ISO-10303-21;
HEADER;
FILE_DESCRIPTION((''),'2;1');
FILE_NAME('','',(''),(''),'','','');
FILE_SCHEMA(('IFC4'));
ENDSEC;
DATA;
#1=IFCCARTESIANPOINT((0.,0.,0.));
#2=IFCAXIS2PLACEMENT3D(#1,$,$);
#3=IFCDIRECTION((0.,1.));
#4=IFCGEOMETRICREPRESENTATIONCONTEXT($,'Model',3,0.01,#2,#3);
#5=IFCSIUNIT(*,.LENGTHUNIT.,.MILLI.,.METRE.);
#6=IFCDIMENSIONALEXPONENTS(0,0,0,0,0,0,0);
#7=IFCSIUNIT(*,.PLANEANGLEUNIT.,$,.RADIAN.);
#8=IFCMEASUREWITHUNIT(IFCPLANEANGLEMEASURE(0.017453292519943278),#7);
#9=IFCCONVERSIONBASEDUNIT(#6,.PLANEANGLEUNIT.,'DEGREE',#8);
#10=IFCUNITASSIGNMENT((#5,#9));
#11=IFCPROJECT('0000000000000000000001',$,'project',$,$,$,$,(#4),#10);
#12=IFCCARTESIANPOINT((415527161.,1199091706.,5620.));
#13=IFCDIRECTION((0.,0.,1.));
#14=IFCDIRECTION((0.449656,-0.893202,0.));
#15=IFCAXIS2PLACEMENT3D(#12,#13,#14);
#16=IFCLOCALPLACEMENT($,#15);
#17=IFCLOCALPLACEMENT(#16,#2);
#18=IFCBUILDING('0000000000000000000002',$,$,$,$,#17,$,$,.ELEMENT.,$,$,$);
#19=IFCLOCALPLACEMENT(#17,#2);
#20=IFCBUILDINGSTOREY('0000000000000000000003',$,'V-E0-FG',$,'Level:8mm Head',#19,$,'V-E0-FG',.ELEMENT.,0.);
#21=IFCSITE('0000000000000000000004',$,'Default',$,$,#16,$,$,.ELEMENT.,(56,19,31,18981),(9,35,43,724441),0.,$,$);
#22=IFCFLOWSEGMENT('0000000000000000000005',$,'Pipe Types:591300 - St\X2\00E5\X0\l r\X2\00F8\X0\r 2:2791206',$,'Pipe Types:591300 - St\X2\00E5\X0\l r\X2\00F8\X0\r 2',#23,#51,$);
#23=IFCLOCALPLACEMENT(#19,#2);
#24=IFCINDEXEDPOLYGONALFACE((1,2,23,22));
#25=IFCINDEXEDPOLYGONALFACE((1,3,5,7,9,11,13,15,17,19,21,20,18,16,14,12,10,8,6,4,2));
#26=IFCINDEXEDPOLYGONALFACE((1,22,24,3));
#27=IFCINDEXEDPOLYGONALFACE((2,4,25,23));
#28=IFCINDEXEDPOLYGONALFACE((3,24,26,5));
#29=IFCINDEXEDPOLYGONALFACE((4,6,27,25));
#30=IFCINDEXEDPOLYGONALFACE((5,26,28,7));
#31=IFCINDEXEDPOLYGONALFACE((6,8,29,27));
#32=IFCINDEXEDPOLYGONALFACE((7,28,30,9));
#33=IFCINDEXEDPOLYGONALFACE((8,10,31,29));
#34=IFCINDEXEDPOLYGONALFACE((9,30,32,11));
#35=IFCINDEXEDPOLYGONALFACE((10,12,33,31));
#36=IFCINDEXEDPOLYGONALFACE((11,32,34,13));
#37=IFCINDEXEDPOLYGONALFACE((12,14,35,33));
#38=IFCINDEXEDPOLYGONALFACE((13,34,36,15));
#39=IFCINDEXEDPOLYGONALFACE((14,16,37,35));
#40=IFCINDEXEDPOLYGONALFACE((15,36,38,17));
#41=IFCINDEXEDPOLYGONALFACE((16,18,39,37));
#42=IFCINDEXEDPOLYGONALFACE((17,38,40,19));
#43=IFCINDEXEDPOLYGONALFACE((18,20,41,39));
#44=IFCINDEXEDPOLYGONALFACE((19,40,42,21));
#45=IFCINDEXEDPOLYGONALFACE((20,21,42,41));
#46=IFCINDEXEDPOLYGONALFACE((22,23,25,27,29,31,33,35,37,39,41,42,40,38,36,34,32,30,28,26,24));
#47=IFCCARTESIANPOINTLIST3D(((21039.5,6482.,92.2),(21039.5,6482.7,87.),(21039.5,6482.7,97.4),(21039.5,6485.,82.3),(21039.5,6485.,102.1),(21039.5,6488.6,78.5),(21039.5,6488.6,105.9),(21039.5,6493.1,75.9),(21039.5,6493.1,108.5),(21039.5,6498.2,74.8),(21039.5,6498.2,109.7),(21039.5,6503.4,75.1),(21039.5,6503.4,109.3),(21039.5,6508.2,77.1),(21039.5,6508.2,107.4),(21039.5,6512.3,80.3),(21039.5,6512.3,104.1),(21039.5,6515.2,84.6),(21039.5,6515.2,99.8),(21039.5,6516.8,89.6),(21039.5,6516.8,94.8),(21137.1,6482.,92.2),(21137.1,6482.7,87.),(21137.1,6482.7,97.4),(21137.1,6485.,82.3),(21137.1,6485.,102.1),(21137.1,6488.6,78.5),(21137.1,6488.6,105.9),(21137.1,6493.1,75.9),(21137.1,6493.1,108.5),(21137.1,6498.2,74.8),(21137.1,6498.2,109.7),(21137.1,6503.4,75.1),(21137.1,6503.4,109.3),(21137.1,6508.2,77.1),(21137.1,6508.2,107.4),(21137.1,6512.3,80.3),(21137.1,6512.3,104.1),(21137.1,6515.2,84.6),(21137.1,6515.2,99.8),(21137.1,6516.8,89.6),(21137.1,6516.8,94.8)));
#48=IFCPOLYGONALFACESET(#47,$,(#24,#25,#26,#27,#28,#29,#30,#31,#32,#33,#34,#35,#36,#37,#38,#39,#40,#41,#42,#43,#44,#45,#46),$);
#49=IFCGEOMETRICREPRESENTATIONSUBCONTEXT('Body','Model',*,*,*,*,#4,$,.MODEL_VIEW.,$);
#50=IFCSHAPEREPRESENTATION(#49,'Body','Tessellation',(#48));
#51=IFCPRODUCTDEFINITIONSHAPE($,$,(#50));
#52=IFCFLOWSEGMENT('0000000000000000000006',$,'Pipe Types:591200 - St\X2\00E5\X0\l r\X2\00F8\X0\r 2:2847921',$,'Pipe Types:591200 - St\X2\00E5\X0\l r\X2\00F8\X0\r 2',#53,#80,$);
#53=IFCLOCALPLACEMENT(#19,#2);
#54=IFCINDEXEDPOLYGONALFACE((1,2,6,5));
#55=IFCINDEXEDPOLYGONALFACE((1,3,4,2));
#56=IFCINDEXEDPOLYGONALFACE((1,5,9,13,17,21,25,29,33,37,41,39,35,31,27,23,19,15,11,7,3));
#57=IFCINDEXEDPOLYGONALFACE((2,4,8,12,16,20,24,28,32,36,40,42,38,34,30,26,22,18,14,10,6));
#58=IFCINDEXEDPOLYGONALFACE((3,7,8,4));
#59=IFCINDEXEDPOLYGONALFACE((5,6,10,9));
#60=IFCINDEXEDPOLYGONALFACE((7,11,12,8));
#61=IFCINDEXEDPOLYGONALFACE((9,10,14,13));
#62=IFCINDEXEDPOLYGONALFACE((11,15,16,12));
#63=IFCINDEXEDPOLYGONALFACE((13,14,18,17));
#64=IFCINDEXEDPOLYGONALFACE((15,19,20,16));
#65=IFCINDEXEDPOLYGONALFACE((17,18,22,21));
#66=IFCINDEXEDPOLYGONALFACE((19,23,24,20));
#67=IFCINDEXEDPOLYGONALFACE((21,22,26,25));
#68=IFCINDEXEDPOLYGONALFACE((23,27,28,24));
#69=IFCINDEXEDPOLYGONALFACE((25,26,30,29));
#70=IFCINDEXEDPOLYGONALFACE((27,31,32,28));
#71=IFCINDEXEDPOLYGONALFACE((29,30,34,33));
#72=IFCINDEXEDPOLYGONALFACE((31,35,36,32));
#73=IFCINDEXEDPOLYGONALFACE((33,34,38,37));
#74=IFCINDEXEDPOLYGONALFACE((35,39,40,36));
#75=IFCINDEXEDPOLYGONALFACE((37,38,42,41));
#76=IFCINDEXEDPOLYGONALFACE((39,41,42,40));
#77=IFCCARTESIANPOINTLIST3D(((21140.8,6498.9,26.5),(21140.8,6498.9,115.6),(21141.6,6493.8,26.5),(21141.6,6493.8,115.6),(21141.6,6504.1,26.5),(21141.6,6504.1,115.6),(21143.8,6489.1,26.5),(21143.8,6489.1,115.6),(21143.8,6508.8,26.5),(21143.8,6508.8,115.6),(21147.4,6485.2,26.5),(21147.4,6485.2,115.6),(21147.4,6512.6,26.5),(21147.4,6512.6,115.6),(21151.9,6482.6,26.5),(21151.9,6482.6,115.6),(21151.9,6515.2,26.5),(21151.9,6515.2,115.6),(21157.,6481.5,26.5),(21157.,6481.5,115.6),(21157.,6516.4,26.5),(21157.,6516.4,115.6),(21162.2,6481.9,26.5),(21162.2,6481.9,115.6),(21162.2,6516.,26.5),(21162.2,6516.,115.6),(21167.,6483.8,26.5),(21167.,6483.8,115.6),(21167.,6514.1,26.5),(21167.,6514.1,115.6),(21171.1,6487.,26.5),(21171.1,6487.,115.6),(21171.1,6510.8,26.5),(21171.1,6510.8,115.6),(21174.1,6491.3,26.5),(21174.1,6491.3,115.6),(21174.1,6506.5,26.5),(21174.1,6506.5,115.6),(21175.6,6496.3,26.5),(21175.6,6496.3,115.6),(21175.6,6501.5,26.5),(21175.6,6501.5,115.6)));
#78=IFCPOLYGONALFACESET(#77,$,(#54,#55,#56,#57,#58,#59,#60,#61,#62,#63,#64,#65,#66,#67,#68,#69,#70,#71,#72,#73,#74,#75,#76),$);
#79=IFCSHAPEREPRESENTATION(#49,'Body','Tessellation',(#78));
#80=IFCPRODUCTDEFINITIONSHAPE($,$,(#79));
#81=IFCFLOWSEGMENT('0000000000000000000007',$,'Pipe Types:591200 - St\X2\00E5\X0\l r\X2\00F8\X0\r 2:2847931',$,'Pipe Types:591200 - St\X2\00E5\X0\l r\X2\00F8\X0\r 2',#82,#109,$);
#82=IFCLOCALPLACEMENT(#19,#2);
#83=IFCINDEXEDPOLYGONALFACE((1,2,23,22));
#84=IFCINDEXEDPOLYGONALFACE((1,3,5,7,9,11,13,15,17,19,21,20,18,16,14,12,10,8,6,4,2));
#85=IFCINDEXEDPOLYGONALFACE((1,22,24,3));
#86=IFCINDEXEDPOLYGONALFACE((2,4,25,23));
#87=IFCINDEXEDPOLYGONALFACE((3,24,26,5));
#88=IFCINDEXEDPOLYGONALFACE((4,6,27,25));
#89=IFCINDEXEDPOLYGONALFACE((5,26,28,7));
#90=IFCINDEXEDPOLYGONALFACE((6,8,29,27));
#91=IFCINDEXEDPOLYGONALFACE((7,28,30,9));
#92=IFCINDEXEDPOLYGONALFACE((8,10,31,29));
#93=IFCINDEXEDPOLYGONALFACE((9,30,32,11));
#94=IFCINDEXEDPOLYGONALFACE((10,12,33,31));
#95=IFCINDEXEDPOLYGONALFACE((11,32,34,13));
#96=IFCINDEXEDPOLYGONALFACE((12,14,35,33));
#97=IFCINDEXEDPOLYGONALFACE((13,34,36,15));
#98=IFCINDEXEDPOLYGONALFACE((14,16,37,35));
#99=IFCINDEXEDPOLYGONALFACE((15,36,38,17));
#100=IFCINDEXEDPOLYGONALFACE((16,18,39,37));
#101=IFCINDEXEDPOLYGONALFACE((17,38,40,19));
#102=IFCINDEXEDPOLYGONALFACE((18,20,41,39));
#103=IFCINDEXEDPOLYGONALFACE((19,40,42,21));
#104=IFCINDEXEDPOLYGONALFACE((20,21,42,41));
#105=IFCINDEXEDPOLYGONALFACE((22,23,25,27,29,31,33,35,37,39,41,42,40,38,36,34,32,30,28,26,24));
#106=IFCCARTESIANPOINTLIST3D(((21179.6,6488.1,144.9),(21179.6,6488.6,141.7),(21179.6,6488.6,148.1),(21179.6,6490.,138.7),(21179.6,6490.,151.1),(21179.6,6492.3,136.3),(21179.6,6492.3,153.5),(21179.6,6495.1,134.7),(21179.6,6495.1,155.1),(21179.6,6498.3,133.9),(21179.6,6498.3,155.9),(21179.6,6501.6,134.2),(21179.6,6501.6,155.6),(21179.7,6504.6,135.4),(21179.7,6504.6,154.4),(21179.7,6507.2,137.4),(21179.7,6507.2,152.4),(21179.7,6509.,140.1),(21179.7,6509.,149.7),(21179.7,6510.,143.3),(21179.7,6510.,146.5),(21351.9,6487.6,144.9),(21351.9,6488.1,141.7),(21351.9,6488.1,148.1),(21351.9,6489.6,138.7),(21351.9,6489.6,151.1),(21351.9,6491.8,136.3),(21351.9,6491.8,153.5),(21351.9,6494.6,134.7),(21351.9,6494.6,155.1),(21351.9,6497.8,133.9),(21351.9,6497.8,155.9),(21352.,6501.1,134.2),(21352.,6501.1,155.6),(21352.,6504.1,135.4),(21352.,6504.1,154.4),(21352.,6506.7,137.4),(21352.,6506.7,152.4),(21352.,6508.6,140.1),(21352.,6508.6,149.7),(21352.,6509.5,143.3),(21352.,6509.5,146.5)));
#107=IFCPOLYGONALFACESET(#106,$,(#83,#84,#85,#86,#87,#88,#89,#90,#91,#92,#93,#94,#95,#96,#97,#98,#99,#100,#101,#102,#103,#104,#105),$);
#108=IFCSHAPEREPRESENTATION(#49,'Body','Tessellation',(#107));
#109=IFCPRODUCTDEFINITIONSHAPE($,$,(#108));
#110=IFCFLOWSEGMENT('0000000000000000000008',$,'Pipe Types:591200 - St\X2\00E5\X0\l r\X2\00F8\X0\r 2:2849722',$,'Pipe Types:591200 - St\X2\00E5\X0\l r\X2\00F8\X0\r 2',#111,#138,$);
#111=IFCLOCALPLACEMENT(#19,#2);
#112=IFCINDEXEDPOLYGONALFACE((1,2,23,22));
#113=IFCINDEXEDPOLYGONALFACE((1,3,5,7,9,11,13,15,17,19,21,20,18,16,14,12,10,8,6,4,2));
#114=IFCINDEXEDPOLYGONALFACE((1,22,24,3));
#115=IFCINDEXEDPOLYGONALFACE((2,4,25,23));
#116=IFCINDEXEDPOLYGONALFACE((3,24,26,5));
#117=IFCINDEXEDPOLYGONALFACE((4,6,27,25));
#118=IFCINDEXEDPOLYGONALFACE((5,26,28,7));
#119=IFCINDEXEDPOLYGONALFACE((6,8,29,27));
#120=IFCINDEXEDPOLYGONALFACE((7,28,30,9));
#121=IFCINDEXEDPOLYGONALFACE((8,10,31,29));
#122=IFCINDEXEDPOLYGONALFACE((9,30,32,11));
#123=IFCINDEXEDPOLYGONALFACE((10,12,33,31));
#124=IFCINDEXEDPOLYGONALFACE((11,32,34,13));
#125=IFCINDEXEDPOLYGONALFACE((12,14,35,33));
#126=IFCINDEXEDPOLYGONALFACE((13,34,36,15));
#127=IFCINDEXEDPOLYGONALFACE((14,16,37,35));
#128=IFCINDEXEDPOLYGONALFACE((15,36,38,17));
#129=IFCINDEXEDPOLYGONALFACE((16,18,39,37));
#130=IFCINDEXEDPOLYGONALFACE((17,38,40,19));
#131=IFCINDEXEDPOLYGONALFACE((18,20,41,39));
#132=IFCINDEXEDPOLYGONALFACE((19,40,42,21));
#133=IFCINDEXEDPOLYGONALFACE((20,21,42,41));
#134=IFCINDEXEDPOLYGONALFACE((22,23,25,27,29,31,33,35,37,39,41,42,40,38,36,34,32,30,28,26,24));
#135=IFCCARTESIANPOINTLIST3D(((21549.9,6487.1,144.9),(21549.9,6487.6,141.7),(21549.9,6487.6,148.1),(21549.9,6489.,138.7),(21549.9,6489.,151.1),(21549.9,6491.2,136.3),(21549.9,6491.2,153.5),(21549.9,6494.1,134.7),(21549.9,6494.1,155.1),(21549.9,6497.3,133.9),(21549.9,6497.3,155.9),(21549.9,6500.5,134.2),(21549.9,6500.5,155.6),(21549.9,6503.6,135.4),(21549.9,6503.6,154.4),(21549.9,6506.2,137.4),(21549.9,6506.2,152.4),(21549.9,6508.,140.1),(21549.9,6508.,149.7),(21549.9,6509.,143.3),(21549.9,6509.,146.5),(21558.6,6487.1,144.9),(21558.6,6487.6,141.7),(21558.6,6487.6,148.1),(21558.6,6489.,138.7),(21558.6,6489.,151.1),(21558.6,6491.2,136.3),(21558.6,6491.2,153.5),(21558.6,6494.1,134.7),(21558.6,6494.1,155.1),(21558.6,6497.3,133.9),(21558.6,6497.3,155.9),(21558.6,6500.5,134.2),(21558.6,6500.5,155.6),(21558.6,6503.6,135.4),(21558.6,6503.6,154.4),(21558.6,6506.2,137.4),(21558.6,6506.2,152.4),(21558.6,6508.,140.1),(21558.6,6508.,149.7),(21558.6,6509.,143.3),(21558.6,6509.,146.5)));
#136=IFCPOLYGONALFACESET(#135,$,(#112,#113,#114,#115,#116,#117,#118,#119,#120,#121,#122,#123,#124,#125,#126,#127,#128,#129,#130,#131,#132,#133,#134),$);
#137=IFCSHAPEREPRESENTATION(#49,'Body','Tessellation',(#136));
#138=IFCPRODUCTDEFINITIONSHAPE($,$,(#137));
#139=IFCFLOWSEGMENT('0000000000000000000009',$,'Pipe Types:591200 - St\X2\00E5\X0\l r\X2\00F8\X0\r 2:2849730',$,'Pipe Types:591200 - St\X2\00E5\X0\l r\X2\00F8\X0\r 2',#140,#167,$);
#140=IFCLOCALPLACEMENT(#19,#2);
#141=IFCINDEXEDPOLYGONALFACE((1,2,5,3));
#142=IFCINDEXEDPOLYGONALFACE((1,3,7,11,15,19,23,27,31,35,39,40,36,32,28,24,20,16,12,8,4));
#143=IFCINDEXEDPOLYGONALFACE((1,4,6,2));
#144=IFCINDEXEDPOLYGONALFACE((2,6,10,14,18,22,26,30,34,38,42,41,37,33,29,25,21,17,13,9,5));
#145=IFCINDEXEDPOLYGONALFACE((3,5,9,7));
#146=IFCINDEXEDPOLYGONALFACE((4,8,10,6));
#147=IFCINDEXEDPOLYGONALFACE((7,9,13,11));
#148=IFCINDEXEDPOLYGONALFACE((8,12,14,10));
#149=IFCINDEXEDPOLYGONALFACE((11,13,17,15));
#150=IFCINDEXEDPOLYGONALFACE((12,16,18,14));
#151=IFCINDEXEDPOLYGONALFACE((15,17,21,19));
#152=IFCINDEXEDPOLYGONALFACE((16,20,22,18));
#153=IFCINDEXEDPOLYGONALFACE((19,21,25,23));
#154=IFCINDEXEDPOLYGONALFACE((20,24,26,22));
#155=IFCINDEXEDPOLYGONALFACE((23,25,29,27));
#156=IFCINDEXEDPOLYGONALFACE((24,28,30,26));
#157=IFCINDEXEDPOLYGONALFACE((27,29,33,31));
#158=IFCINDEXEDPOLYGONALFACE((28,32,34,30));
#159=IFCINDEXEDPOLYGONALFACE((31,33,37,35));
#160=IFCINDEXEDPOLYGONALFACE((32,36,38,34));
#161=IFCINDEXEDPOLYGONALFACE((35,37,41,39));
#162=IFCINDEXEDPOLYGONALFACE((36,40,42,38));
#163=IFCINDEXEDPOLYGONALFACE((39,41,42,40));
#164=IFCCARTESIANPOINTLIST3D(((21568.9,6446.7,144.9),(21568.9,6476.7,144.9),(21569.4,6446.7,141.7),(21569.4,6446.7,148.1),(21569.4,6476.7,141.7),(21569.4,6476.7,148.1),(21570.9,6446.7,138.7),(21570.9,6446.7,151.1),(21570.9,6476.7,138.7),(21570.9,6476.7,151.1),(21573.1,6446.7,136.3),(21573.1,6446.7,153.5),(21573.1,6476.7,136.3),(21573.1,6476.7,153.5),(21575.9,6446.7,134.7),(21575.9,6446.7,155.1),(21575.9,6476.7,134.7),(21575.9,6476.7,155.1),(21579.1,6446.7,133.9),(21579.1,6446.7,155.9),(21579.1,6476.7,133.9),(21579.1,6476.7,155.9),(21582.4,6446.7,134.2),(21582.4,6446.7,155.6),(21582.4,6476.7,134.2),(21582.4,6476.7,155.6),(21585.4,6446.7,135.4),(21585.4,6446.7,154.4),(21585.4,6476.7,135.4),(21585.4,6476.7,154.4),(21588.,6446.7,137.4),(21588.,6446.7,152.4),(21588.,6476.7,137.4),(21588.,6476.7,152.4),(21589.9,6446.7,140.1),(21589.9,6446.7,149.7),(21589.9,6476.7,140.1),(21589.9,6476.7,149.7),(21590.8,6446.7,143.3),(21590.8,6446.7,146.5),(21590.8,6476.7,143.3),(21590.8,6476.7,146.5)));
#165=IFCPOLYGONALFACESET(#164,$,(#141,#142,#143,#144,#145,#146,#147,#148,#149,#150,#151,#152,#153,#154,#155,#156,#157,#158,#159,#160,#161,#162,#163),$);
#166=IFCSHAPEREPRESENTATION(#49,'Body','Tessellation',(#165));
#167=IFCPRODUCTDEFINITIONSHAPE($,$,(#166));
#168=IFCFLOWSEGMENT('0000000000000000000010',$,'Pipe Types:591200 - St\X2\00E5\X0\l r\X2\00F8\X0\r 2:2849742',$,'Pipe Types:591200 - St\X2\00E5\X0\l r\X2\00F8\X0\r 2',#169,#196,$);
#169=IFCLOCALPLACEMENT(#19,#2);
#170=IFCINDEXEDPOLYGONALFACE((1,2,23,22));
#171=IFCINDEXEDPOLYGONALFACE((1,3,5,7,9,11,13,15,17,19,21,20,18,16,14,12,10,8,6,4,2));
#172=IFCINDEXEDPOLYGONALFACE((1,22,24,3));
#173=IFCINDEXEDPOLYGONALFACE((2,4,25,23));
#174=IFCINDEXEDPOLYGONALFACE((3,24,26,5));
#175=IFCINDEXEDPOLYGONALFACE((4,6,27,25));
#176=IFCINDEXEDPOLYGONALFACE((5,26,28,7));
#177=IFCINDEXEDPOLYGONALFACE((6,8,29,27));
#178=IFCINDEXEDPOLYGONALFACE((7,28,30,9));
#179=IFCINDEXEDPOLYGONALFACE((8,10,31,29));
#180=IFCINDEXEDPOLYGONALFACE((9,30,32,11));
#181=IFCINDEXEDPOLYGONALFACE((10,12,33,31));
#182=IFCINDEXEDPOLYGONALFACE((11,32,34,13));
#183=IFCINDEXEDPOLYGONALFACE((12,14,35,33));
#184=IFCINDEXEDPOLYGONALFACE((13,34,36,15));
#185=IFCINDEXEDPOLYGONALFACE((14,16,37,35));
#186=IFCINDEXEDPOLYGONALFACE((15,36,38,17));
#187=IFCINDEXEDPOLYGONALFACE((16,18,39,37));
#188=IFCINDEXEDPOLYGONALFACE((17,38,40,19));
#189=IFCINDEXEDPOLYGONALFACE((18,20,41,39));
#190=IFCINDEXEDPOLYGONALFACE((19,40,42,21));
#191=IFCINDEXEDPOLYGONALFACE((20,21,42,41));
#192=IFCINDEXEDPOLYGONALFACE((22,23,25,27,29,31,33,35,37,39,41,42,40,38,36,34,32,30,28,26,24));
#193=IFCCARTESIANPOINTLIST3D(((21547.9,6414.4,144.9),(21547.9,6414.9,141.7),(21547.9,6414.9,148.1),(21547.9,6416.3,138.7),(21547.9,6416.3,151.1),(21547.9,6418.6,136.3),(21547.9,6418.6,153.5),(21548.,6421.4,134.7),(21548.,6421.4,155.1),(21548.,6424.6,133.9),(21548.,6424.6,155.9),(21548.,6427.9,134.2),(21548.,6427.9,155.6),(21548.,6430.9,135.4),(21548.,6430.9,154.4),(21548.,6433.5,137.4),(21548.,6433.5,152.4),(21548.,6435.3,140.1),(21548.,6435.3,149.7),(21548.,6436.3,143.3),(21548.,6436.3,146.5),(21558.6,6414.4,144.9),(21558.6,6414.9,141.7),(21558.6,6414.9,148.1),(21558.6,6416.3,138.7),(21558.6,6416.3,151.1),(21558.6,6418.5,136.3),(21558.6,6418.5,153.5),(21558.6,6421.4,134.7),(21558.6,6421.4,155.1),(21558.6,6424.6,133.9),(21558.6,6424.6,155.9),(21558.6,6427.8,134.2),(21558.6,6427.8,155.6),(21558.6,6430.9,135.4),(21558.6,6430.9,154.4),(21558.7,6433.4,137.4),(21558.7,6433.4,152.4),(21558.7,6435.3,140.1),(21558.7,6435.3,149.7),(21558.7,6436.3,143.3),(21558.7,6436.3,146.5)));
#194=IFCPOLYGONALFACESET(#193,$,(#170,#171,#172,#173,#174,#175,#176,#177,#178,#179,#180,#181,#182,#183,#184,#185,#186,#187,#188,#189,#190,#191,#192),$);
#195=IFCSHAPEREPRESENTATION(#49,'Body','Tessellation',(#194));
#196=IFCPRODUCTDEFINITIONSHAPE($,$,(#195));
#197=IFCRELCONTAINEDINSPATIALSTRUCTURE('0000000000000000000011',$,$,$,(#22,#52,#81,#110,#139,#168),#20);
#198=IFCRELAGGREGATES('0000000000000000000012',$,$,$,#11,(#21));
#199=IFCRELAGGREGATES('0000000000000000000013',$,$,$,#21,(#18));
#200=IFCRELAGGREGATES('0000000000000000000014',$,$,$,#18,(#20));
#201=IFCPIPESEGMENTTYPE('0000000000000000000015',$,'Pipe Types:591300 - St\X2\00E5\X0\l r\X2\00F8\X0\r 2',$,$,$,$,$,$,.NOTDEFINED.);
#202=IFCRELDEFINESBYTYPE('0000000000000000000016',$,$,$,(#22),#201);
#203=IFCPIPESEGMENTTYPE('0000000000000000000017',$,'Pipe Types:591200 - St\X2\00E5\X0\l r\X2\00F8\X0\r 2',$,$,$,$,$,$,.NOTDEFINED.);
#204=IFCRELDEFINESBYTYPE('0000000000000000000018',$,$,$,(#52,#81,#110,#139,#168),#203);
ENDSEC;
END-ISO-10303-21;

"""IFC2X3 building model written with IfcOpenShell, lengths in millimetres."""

from ifc_helpers import new_model, entity, si_unit, converted_unit, direction, frame, frame_2d, origin, origin_2d_with_axis, place, context, subcontext, project, spatial, circle, extrude, type_object, element, save


model = new_model("IFC2X3")

# Units and contexts
model_context = context("Model", 3, precision=0.01, world=origin(), true_north=direction((0.0, 1.0)))
body_context = subcontext(model_context, "Body", "Model", "MODEL_VIEW")
ifc_project = project(units=[si_unit("LENGTHUNIT", "METRE", prefix="MILLI"), converted_unit("PLANEANGLEUNIT", "DEGREE", entity("IfcPlaneAngleMeasure", 0.017453292519943278), si_unit("PLANEANGLEUNIT", "RADIAN"), dimensions=[0, 0, 0, 0, 0, 0, 0])], contexts=[model_context])

# Site, building, storey
site_placement = place(None, frame((415527161.0, 1199091706.0, 5620.0), z_axis=(0.0, 0.0, 1.0), x_axis=(0.449656, -0.893202, 0.0)))
site = spatial("IfcSite", under=ifc_project, at=site_placement, Name="Default", CompositionType="ELEMENT", RefLatitude=(56, 19, 31, 18981), RefLongitude=(9, 35, 43, 724441), RefElevation=0.0)
building_placement = place(site_placement, origin())
building = spatial("IfcBuilding", under=site, at=building_placement, CompositionType="ELEMENT")
storey_placement = place(building_placement, origin())
storey = spatial("IfcBuildingStorey", under=building, at=storey_placement, Name="V-E0-FG", ObjectType="Level:8mm Head", LongName="V-E0-FG", CompositionType="ELEMENT", Elevation=0.0)

# Flow segments
pipe_segment_type_1 = type_object("IfcPipeSegmentType", Name="Pipe Types:591300 - Stål rør 2", PredefinedType="NOTDEFINED")
flow_segment_1_placement = place(storey_placement, origin())
element("IfcFlowSegment", 1, at=flow_segment_1_placement, inside=storey, type_object=pipe_segment_type_1, Name="Pipe Types:591300 - Stål rør 2:2791206", ObjectType="Pipe Types:591300 - Stål rør 2", context=body_context, shape_type="SweptSolid", body=[
    extrude(circle(Radius=17.5, at=frame_2d((0.0, 0.0), x_axis=(1.0, 0.0))), frame((21039.5, 6499.5, 92.2), z_axis=(1.0, 0.0, 0.0), x_axis=(0.0, -1.0, 0.0)), (0.0, 0.0, 1.0), 97.7),
])
pipe_segment_type_2 = type_object("IfcPipeSegmentType", Name="Pipe Types:591200 - Stål rør 2", PredefinedType="NOTDEFINED")
flow_segment_2_placement = place(storey_placement, origin())
element("IfcFlowSegment", 2, at=flow_segment_2_placement, inside=storey, type_object=pipe_segment_type_2, Name="Pipe Types:591200 - Stål rør 2:2847921", ObjectType="Pipe Types:591200 - Stål rør 2", context=body_context, shape_type="SweptSolid", body=[
    extrude(circle(Radius=17.5, at=origin_2d_with_axis()), frame((21158.3, 6498.9, 26.5), z_axis=(0.0, 0.0, 1.0), x_axis=(-1.0, 0.0, 0.0)), (0.0, 0.0, 1.0), 89.1),
])
flow_segment_3_placement = place(storey_placement, origin())
element("IfcFlowSegment", 3, at=flow_segment_3_placement, inside=storey, type_object=pipe_segment_type_2, Name="Pipe Types:591200 - Stål rør 2:2847931", ObjectType="Pipe Types:591200 - Stål rør 2", context=body_context, shape_type="SweptSolid", body=[
    extrude(circle(Radius=11.0, at=frame_2d((0.0, 0.0), x_axis=(1.0, 0.0))), frame((21179.6, 6499.1, 144.9), z_axis=(0.999996, -0.002778, 0.0), x_axis=(-0.002778, -0.999996, 0.0)), (0.0, 0.0, 1.0), 172.3),
])
flow_segment_4_placement = place(storey_placement, origin())
element("IfcFlowSegment", 4, at=flow_segment_4_placement, inside=storey, type_object=pipe_segment_type_2, Name="Pipe Types:591200 - Stål rør 2:2849722", ObjectType="Pipe Types:591200 - Stål rør 2", context=body_context, shape_type="SweptSolid", body=[
    extrude(circle(Radius=11.0, at=origin_2d_with_axis()), frame((21549.9, 6498.1, 144.9), z_axis=(1.0, 0.0, 0.0), x_axis=(0.0, -1.0, 0.0)), (0.0, 0.0, 1.0), 8.7),
])
flow_segment_5_placement = place(storey_placement, origin())
element("IfcFlowSegment", 5, at=flow_segment_5_placement, inside=storey, type_object=pipe_segment_type_2, Name="Pipe Types:591200 - Stål rør 2:2849730", ObjectType="Pipe Types:591200 - Stål rør 2", context=body_context, shape_type="SweptSolid", body=[
    extrude(circle(Radius=11.0, at=frame_2d((0.0, 0.0), x_axis=(1.0, 0.0))), frame((21579.9, 6446.7, 144.9), z_axis=(0.0, 1.0, 0.0), x_axis=(-1.0, 0.0, 0.0)), (0.0, 0.0, 1.0), 30.0),
])
flow_segment_6_placement = place(storey_placement, origin())
element("IfcFlowSegment", 6, at=flow_segment_6_placement, inside=storey, type_object=pipe_segment_type_2, Name="Pipe Types:591200 - Stål rør 2:2849742", ObjectType="Pipe Types:591200 - Stål rør 2", context=body_context, shape_type="SweptSolid", body=[
    extrude(circle(Radius=11.0, at=origin_2d_with_axis()), frame((21548.0, 6425.4, 144.9), z_axis=(0.999992, -0.004082, 0.0), x_axis=(-0.004082, -0.999992, 0.0)), (0.0, 0.0, 1.0), 10.7),
])

save(model, "model.ifc")
